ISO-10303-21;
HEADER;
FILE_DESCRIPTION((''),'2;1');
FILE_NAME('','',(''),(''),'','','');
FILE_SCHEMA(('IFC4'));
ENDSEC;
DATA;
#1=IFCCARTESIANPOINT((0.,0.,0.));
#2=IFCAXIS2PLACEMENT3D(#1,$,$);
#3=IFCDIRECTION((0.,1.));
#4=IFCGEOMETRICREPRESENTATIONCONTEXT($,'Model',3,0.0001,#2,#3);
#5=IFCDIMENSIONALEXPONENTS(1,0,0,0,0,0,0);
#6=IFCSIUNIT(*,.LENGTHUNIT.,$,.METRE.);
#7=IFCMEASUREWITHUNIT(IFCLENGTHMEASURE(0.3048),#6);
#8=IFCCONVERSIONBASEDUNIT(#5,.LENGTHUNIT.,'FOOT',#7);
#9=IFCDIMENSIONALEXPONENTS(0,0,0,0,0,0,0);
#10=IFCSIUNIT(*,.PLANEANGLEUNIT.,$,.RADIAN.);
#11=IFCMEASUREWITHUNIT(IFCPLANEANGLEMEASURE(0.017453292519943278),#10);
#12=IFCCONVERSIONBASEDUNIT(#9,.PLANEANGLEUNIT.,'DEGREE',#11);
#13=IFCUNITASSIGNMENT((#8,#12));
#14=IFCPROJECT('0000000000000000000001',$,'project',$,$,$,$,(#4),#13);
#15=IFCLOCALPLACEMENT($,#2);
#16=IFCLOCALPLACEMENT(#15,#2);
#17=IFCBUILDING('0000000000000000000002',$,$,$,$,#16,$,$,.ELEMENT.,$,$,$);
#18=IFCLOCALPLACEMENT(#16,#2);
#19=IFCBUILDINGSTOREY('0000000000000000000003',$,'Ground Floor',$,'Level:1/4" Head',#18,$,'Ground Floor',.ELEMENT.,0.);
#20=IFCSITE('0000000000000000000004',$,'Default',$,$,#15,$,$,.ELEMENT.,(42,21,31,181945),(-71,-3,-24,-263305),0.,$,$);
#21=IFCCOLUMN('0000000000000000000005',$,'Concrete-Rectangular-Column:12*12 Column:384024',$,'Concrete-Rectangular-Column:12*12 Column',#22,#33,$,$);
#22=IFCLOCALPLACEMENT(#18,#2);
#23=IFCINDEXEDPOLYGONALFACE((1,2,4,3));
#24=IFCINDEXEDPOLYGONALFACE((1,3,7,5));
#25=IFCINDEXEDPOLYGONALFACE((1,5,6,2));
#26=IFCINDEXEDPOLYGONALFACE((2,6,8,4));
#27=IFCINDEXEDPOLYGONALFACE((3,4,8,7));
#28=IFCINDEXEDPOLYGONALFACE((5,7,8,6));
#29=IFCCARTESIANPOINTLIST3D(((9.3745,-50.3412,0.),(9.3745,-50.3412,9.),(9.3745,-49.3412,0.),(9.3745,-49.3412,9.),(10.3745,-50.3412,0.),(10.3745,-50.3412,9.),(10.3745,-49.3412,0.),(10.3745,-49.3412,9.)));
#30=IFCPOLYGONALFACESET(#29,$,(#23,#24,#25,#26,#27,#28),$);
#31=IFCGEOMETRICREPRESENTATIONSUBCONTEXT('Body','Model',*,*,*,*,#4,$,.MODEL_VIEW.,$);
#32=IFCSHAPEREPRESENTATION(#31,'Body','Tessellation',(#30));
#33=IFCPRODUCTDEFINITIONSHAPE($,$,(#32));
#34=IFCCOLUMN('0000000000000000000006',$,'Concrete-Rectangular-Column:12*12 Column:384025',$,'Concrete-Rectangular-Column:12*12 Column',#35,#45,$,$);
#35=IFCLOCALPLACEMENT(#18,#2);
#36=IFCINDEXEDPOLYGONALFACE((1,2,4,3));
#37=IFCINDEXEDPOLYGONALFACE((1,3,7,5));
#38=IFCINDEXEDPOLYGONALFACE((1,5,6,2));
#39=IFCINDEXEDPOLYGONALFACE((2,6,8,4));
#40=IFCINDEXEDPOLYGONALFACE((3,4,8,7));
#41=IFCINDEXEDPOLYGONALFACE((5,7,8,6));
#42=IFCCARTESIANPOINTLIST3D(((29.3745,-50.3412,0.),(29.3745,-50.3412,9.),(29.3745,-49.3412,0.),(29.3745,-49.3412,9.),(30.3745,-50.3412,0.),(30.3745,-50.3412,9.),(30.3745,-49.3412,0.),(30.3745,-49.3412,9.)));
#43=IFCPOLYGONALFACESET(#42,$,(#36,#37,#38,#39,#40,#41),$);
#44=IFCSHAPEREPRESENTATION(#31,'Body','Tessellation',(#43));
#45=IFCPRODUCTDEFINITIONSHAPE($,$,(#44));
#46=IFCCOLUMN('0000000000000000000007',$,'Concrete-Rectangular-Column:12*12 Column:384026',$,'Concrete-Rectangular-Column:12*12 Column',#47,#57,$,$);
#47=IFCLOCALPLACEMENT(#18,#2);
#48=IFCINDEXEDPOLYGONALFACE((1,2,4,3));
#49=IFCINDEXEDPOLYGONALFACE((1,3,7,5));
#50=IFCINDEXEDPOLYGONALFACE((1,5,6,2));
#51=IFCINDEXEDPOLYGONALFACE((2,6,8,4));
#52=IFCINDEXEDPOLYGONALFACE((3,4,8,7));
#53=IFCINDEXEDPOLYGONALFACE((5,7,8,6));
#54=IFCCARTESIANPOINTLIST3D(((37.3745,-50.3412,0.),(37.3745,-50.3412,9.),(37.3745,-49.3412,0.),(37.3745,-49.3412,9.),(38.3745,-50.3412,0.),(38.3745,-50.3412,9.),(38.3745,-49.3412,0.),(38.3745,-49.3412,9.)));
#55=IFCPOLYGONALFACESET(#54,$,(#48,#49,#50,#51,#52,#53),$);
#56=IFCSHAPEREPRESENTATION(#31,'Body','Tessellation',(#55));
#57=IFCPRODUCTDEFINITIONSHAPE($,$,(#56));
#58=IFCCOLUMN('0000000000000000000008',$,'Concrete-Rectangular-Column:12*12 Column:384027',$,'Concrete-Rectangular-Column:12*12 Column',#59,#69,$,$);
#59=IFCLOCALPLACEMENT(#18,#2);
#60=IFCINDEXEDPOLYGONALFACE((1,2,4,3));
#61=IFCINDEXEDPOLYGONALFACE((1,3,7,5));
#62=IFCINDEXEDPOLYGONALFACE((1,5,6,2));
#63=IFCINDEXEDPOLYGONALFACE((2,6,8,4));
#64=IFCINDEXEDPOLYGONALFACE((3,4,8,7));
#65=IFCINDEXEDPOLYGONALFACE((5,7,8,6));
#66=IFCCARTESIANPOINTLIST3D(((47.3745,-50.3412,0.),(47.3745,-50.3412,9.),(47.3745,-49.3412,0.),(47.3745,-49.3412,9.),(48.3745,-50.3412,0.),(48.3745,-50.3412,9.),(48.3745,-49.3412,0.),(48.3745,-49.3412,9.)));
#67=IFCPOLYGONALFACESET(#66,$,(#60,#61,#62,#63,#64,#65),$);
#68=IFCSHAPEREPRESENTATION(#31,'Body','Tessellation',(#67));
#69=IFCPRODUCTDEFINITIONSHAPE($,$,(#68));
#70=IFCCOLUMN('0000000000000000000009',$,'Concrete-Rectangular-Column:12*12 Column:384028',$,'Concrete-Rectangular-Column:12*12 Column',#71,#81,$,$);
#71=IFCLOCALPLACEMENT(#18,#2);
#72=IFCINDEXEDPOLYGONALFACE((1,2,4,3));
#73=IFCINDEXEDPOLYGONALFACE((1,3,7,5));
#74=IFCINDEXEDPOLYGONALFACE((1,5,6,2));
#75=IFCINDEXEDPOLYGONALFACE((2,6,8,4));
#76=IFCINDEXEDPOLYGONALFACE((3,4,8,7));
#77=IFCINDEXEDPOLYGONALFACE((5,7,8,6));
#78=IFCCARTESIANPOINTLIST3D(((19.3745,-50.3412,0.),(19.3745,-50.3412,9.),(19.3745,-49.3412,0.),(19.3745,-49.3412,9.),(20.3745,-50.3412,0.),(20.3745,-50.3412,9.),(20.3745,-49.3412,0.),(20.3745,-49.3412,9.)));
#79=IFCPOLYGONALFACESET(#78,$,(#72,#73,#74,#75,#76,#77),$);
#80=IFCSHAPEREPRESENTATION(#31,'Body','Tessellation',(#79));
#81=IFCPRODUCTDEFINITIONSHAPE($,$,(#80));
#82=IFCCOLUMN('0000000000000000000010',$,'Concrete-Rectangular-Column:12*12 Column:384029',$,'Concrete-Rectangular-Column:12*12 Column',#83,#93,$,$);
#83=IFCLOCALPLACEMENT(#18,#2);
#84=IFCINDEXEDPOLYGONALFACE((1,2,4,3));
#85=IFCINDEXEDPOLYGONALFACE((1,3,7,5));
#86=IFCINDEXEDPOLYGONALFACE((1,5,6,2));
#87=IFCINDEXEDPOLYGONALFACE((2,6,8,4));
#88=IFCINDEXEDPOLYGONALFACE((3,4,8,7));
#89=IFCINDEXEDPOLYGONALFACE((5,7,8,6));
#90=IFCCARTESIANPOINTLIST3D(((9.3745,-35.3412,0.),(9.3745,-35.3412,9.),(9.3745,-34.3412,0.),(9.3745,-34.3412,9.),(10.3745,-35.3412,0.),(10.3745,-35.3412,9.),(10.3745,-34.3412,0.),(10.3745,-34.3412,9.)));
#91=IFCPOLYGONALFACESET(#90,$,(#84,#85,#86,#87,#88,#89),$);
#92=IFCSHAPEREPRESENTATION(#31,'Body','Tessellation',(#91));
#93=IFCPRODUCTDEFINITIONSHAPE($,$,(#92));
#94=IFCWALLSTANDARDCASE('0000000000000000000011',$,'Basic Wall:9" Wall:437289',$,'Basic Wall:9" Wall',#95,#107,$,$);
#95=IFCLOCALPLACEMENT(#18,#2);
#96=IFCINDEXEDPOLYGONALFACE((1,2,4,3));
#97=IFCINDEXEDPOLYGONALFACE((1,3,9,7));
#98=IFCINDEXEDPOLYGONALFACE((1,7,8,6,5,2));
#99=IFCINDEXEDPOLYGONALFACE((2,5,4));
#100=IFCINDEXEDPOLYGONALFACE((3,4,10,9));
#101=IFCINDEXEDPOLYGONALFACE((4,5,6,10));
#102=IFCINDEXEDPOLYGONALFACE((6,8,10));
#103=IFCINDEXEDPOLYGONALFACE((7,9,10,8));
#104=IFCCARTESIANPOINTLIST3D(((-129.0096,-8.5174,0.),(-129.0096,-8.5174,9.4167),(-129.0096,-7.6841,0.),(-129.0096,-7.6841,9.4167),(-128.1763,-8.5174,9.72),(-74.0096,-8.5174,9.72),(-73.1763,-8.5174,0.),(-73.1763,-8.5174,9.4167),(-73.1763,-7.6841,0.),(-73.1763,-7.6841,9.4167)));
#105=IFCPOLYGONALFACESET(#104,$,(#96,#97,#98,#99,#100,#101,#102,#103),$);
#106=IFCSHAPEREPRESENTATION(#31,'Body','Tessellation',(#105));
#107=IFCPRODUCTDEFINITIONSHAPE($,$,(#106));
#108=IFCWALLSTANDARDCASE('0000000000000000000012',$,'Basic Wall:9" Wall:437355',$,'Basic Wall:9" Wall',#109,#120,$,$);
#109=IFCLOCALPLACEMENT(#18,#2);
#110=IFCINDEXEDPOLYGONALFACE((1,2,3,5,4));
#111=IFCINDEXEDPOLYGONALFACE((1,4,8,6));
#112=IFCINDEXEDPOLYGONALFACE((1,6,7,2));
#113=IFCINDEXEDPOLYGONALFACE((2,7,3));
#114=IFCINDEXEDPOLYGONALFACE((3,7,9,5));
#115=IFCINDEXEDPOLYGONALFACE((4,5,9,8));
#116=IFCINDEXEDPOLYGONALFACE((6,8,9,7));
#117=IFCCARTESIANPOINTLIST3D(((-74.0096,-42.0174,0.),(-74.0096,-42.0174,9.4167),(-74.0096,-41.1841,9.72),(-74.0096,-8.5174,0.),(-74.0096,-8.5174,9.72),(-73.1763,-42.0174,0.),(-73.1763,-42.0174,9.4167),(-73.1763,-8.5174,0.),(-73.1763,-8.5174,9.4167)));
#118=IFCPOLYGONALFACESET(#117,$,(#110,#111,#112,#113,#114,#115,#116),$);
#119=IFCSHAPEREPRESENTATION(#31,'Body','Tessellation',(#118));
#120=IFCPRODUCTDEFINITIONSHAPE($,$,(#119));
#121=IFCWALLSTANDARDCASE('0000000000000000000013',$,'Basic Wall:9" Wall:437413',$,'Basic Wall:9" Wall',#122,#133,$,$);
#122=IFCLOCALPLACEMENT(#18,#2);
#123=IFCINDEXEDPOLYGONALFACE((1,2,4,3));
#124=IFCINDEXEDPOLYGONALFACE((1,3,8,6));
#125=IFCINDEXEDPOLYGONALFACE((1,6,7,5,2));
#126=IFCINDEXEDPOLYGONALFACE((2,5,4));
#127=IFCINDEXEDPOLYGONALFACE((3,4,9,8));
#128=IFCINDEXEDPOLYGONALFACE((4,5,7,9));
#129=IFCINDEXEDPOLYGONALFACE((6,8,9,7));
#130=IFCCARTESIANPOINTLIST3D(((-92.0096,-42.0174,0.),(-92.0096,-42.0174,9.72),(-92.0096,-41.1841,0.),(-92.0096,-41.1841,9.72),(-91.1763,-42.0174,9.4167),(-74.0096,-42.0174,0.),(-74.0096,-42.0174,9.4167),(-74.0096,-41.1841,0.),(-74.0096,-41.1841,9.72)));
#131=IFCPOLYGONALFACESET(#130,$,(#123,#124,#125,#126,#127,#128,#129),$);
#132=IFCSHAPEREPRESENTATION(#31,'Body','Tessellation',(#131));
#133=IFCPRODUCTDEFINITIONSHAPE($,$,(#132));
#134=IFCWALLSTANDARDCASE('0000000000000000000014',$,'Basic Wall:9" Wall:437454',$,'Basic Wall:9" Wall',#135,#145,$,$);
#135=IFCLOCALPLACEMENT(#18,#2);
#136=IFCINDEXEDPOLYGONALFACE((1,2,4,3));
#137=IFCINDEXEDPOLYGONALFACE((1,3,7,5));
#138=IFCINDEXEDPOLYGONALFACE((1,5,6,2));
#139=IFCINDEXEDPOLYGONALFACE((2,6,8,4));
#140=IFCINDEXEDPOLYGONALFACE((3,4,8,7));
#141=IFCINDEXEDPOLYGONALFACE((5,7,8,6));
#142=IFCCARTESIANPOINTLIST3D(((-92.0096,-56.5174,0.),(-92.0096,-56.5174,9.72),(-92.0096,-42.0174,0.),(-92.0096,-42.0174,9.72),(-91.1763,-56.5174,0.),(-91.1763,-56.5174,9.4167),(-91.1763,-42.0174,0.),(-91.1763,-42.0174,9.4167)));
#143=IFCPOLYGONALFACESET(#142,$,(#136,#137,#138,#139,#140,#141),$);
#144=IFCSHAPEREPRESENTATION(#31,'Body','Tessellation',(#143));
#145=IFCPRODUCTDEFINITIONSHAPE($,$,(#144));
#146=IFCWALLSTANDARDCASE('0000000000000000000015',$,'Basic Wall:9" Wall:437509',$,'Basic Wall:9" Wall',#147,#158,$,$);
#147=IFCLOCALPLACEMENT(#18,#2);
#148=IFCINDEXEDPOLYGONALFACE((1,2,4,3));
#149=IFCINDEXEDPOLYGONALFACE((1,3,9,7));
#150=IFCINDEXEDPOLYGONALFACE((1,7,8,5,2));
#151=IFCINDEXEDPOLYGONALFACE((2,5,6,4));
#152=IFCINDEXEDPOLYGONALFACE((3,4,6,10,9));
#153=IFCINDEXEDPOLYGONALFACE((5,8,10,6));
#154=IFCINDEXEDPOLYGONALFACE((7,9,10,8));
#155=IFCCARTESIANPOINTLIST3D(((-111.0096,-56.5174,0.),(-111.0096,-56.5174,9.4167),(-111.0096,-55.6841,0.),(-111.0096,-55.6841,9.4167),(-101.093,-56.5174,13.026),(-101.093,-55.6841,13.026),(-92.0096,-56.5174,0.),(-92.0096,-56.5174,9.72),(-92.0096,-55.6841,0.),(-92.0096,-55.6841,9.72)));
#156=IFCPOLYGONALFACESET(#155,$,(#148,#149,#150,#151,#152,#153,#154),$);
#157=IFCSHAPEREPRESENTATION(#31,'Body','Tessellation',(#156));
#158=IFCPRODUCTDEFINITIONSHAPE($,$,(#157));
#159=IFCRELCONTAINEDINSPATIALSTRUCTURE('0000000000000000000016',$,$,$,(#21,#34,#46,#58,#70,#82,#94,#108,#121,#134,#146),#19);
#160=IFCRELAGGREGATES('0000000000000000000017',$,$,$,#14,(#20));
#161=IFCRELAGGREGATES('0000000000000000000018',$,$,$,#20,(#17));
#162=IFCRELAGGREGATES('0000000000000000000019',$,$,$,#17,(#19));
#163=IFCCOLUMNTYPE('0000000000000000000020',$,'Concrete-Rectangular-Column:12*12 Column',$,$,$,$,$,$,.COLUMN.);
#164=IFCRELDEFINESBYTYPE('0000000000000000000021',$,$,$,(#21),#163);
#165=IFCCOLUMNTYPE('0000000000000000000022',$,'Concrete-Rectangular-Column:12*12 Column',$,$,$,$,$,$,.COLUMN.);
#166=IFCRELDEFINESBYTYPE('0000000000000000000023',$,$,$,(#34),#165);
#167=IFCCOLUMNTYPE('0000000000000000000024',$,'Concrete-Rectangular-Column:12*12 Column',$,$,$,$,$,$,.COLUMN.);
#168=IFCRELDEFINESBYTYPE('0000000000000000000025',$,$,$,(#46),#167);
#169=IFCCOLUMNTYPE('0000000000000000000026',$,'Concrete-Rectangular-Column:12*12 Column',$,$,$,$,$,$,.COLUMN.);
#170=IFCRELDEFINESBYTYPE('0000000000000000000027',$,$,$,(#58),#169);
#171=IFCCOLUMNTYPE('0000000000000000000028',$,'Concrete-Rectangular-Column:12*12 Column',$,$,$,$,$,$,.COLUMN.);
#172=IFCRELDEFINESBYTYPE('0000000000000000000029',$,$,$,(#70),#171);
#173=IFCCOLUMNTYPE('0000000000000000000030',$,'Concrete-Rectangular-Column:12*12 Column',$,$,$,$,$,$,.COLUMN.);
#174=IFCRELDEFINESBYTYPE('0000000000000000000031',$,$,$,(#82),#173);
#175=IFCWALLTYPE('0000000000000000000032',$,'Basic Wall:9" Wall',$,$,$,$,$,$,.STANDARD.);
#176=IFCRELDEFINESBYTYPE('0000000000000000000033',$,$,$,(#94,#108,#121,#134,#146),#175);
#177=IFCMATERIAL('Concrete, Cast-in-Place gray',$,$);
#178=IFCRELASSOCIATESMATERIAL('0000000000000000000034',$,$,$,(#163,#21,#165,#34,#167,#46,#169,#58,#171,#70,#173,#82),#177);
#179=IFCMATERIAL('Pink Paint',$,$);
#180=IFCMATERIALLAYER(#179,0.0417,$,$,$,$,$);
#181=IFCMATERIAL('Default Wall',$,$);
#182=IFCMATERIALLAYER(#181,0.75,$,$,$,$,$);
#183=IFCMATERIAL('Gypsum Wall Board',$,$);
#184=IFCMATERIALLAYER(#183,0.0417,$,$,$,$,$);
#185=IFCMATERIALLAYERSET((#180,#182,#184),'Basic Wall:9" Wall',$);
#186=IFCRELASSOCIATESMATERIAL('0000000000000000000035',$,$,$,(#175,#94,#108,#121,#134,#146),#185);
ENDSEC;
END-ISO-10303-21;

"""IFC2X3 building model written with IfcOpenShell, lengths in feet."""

from ifc_helpers import new_model, entity, si_unit, converted_unit, direction, frame, frame_2d, origin, origin_2d_with_axis, place, context, subcontext, project, spatial, polyline, rectangle, extrude, clip, bounded_halfspace, source, transform, mapped, material, layer, layer_set, layer_usage, type_object, type_shapes, element, save


model = new_model("IFC2X3")

# Units and contexts
model_context = context("Model", 3, precision=0.0001, world=origin(), true_north=direction((0.0, 1.0)))
body_context = subcontext(model_context, "Body", "Model", "MODEL_VIEW")
ifc_project = project(units=[converted_unit("LENGTHUNIT", "FOOT", entity("IfcLengthMeasure", 0.3048), si_unit("LENGTHUNIT", "METRE"), dimensions=[1, 0, 0, 0, 0, 0, 0]), converted_unit("PLANEANGLEUNIT", "DEGREE", entity("IfcPlaneAngleMeasure", 0.017453292519943278), si_unit("PLANEANGLEUNIT", "RADIAN"), dimensions=[0, 0, 0, 0, 0, 0, 0])], contexts=[model_context])

# Site, building, storey
site_placement = place(None, origin())
site = spatial("IfcSite", under=ifc_project, at=site_placement, Name="Default", CompositionType="ELEMENT", RefLatitude=(42, 21, 31, 181945), RefLongitude=(-71, -3, -24, -263305), RefElevation=0.0)
building_placement = place(site_placement, origin())
building = spatial("IfcBuilding", under=site, at=building_placement, CompositionType="ELEMENT")
storey_placement = place(building_placement, origin())
storey = spatial("IfcBuildingStorey", under=building, at=storey_placement, Name="Ground Floor", ObjectType="Level:1/4\" Head", LongName="Ground Floor", CompositionType="ELEMENT", Elevation=0.0)

# Columns
ifc_material_1 = material(Name="Concrete, Cast-in-Place gray")
column_type_1 = type_object("IfcColumnType", Name="Concrete-Rectangular-Column:12*12 Column", PredefinedType="COLUMN", material=ifc_material_1)
shared_shape_1 = source(origin(), body_context, "Body", "SweptSolid", [
    extrude(rectangle(XDim=1.0, YDim=1.0, at=origin_2d_with_axis()), frame((9.8745, -49.8412, 0.0), z_axis=(0.0, 0.0, 1.0), x_axis=(-1.0, 0.0, 0.0)), (0.0, 0.0, 1.0), 9.0),
])
type_shapes(column_type_1, [shared_shape_1])
column_1_placement = place(storey_placement, origin())
element("IfcColumn", 1, at=column_1_placement, inside=storey, type_object=column_type_1, material=ifc_material_1, Name="Concrete-Rectangular-Column:12*12 Column:384024", ObjectType="Concrete-Rectangular-Column:12*12 Column", context=body_context, shape_type="MappedRepresentation", body=[
    mapped(shared_shape_1, transform((0.0, 0.0, 0.0), scale=1.0)),
])
column_type_2 = type_object("IfcColumnType", Name="Concrete-Rectangular-Column:12*12 Column", PredefinedType="COLUMN", material=ifc_material_1)
shared_shape_2 = source(origin(), body_context, "Body", "SweptSolid", [
    extrude(rectangle(XDim=1.0, YDim=1.0, at=frame_2d((0.0, 0.0), x_axis=(1.0, 0.0))), frame((29.8745, -49.8412, 0.0), z_axis=(0.0, 0.0, 1.0), x_axis=(-1.0, 0.0, 0.0)), (0.0, 0.0, 1.0), 9.0),
])
type_shapes(column_type_2, [shared_shape_2])
column_2_placement = place(storey_placement, origin())
element("IfcColumn", 2, at=column_2_placement, inside=storey, type_object=column_type_2, material=ifc_material_1, Name="Concrete-Rectangular-Column:12*12 Column:384025", ObjectType="Concrete-Rectangular-Column:12*12 Column", context=body_context, shape_type="MappedRepresentation", body=[
    mapped(shared_shape_2, transform((0.0, 0.0, 0.0), scale=1.0)),
])
column_type_3 = type_object("IfcColumnType", Name="Concrete-Rectangular-Column:12*12 Column", PredefinedType="COLUMN", material=ifc_material_1)
shared_shape_3 = source(origin(), body_context, "Body", "SweptSolid", [
    extrude(rectangle(XDim=1.0, YDim=1.0, at=origin_2d_with_axis()), frame((37.8745, -49.8412, 0.0), z_axis=(0.0, 0.0, 1.0), x_axis=(-1.0, 0.0, 0.0)), (0.0, 0.0, 1.0), 9.0),
])
type_shapes(column_type_3, [shared_shape_3])
column_3_placement = place(storey_placement, origin())
element("IfcColumn", 3, at=column_3_placement, inside=storey, type_object=column_type_3, material=ifc_material_1, Name="Concrete-Rectangular-Column:12*12 Column:384026", ObjectType="Concrete-Rectangular-Column:12*12 Column", context=body_context, shape_type="MappedRepresentation", body=[
    mapped(shared_shape_3, transform((0.0, 0.0, 0.0), scale=1.0)),
])
column_type_4 = type_object("IfcColumnType", Name="Concrete-Rectangular-Column:12*12 Column", PredefinedType="COLUMN", material=ifc_material_1)
shared_shape_4 = source(origin(), body_context, "Body", "SweptSolid", [
    extrude(rectangle(XDim=1.0, YDim=1.0, at=origin_2d_with_axis()), frame((47.8745, -49.8412, 0.0), z_axis=(0.0, 0.0, 1.0), x_axis=(-1.0, 0.0, 0.0)), (0.0, 0.0, 1.0), 9.0),
])
type_shapes(column_type_4, [shared_shape_4])
column_4_placement = place(storey_placement, origin())
element("IfcColumn", 4, at=column_4_placement, inside=storey, type_object=column_type_4, material=ifc_material_1, Name="Concrete-Rectangular-Column:12*12 Column:384027", ObjectType="Concrete-Rectangular-Column:12*12 Column", context=body_context, shape_type="MappedRepresentation", body=[
    mapped(shared_shape_4, transform((0.0, 0.0, 0.0), scale=1.0)),
])
column_type_5 = type_object("IfcColumnType", Name="Concrete-Rectangular-Column:12*12 Column", PredefinedType="COLUMN", material=ifc_material_1)
shared_shape_5 = source(origin(), body_context, "Body", "SweptSolid", [
    extrude(rectangle(XDim=1.0, YDim=1.0, at=frame_2d((0.0, 0.0), x_axis=(1.0, 0.0))), frame((19.8745, -49.8412, 0.0), z_axis=(0.0, 0.0, 1.0), x_axis=(-1.0, 0.0, 0.0)), (0.0, 0.0, 1.0), 9.0),
])
type_shapes(column_type_5, [shared_shape_5])
column_5_placement = place(storey_placement, origin())
element("IfcColumn", 5, at=column_5_placement, inside=storey, type_object=column_type_5, material=ifc_material_1, Name="Concrete-Rectangular-Column:12*12 Column:384028", ObjectType="Concrete-Rectangular-Column:12*12 Column", context=body_context, shape_type="MappedRepresentation", body=[
    mapped(shared_shape_5, transform((0.0, 0.0, 0.0), scale=1.0)),
])
column_type_6 = type_object("IfcColumnType", Name="Concrete-Rectangular-Column:12*12 Column", PredefinedType="COLUMN", material=ifc_material_1)
shared_shape_6 = source(origin(), body_context, "Body", "SweptSolid", [
    extrude(rectangle(XDim=1.0, YDim=1.0, at=origin_2d_with_axis()), frame((9.8745, -34.8412, 0.0), z_axis=(0.0, 0.0, 1.0), x_axis=(-1.0, 0.0, 0.0)), (0.0, 0.0, 1.0), 9.0),
])
type_shapes(column_type_6, [shared_shape_6])
column_6_placement = place(storey_placement, origin())
element("IfcColumn", 6, at=column_6_placement, inside=storey, type_object=column_type_6, material=ifc_material_1, Name="Concrete-Rectangular-Column:12*12 Column:384029", ObjectType="Concrete-Rectangular-Column:12*12 Column", context=body_context, shape_type="MappedRepresentation", body=[
    mapped(shared_shape_6, transform((0.0, 0.0, 0.0), scale=1.0)),
])

# Walls
ifc_material_2 = material(Name="Pink Paint")
ifc_layer_1 = layer(ifc_material_2, 0.0417)
ifc_material_3 = material(Name="Default Wall")
ifc_layer_2 = layer(ifc_material_3, 0.75)
ifc_material_4 = material(Name="Gypsum Wall Board")
ifc_layer_3 = layer(ifc_material_4, 0.0417)
ifc_layer_set_1 = layer_set([ifc_layer_1, ifc_layer_2, ifc_layer_3], Name="Basic Wall:9\" Wall")
ifc_layer_usage_1 = layer_usage(ifc_layer_set_1, "AXIS2", "NEGATIVE", 0.4167)
wall_type_1 = type_object("IfcWallType", Name="Basic Wall:9\" Wall", PredefinedType="STANDARD", material=ifc_layer_set_1)
wall_1_placement = place(storey_placement, frame((-129.0096, -8.1008, 0.0)))
element("IfcWallStandardCase", 7, at=wall_1_placement, inside=storey, type_object=wall_type_1, material=ifc_layer_usage_1, Name="Basic Wall:9\" Wall:437289", ObjectType="Basic Wall:9\" Wall", context=body_context, shape_type="Clipping", body=[
    clip(clip(clip(extrude(rectangle(XDim=55.8333, YDim=0.8333, at=frame_2d((27.9167, 0.0), x_axis=(-1.0, 0.0))), origin(), (0.0, 0.0, 1.0), 9.72), bounded_halfspace(frame((0.0, -0.4167, 9.4167), z_axis=(-0.34202, 0.0, 0.939693), x_axis=(0.0, -1.0, 0.0)), False, frame((0.0, -0.4167, 9.4167)), polyline([(0.0, 0.0), (0.8333, 0.0), (0.0, 0.8333), (0.0, 0.0)]))), bounded_halfspace(frame((55.0, -0.4167, 9.72), z_axis=(0.34202, 0.0, 0.939693), x_axis=(0.0, 1.0, 0.0)), False, frame((55.0, -0.4167, 9.72)), polyline([(0.0, 0.0), (0.8333, 0.0), (0.8333, 0.8333), (0.0, 0.0)]))), bounded_halfspace(frame((0.8333, -0.4167, 9.72), z_axis=(0.0, 0.34202, 0.939693), x_axis=(-1.0, 0.0, 0.0)), False, frame((0.8333, -0.4167, 9.72)), polyline([(0.0, 0.0), (54.1667, 0.0), (55.0, 0.8333), (-0.8333, 0.8333), (0.0, 0.0)]))),
])
wall_2_placement = place(storey_placement, frame((-73.593, -8.5174, 0.0), z_axis=(0.0, 0.0, 1.0), x_axis=(0.0, -1.0, 0.0)))
element("IfcWallStandardCase", 8, at=wall_2_placement, inside=storey, type_object=wall_type_1, material=ifc_layer_usage_1, Name="Basic Wall:9\" Wall:437355", ObjectType="Basic Wall:9\" Wall", context=body_context, shape_type="Clipping", body=[
    clip(clip(extrude(rectangle(XDim=33.5, YDim=0.8333, at=frame_2d((16.75, 0.0), x_axis=(-1.0, 0.0))), origin(), (0.0, 0.0, 1.0), 9.72), bounded_halfspace(frame((0.0, -0.4167, 9.72), z_axis=(0.0, 0.34202, 0.939693), x_axis=(-1.0, 0.0, 0.0)), False, frame((0.0, -0.4167, 9.72)), polyline([(0.0, 0.0), (32.6667, 0.0), (33.5, 0.8333), (0.0, 0.8333), (0.0, 0.0)]))), bounded_halfspace(frame((32.6667, -0.4167, 9.72), z_axis=(0.34202, 0.0, 0.939693), x_axis=(0.0, 1.0, 0.0)), False, frame((32.6667, -0.4167, 9.72)), polyline([(0.0, 0.0), (0.8333, 0.0), (0.8333, 0.8333), (0.0, 0.0)]))),
])
wall_3_placement = place(storey_placement, frame((-74.0096, -41.6008, 0.0), z_axis=(0.0, 0.0, 1.0), x_axis=(-1.0, 0.0, 0.0)))
element("IfcWallStandardCase", 9, at=wall_3_placement, inside=storey, type_object=wall_type_1, material=ifc_layer_usage_1, Name="Basic Wall:9\" Wall:437413", ObjectType="Basic Wall:9\" Wall", context=body_context, shape_type="Clipping", body=[
    clip(clip(extrude(rectangle(XDim=18.0, YDim=0.8333, at=frame_2d((9.0, 0.0), x_axis=(-1.0, 0.0))), origin(), (0.0, 0.0, 1.0), 9.72), bounded_halfspace(frame((18.0, -0.4167, 9.72), z_axis=(-0.34202, 0.0, 0.939693), x_axis=(0.0, -1.0, 0.0)), False, frame((18.0, -0.4167, 9.72)), polyline([(0.0, 0.0), (0.0, 0.8333), (-0.8333, 0.8333), (0.0, 0.0)]))), bounded_halfspace(frame((0.0, -0.4167, 9.72), z_axis=(0.0, 0.34202, 0.939693), x_axis=(-1.0, 0.0, 0.0)), False, frame((0.0, -0.4167, 9.72)), polyline([(0.0, 0.0), (18.0, 0.0), (17.1667, 0.8333), (0.0, 0.8333), (0.0, 0.0)]))),
])
wall_4_placement = place(storey_placement, frame((-91.593, -42.0174, 0.0), z_axis=(0.0, 0.0, 1.0), x_axis=(0.0, -1.0, 0.0)))
element("IfcWallStandardCase", 10, at=wall_4_placement, inside=storey, type_object=wall_type_1, material=ifc_layer_usage_1, Name="Basic Wall:9\" Wall:437454", ObjectType="Basic Wall:9\" Wall", context=body_context, shape_type="Clipping", body=[
    clip(extrude(rectangle(XDim=14.5, YDim=0.8333, at=frame_2d((7.25, 0.0), x_axis=(-1.0, 0.0))), origin(), (0.0, 0.0, 1.0), 9.72), bounded_halfspace(frame((0.0, -0.4167, 9.72), z_axis=(0.0, 0.34202, 0.939693), x_axis=(-1.0, 0.0, 0.0)), False, frame((0.0, -0.4167, 9.72)), polyline([(0.0, 0.0), (13.6667, 0.0), (14.5, 0.0), (14.5, 0.8333), (0.0, 0.8333), (0.0, 0.0)]))),
])
wall_5_placement = place(storey_placement, frame((-92.0096, -56.1008, 0.0), z_axis=(0.0, 0.0, 1.0), x_axis=(-1.0, 0.0, 0.0)))
element("IfcWallStandardCase", 11, at=wall_5_placement, inside=storey, type_object=wall_type_1, material=ifc_layer_usage_1, Name="Basic Wall:9\" Wall:437509", ObjectType="Basic Wall:9\" Wall", context=body_context, shape_type="Clipping", body=[
    clip(clip(extrude(rectangle(XDim=19.0, YDim=0.8333, at=frame_2d((9.5, 0.0), x_axis=(-1.0, 0.0))), origin(), (0.0, 0.0, 1.0), 13.026), bounded_halfspace(frame((9.0833, -0.4167, 13.026), z_axis=(0.34202, 0.0, 0.939693), x_axis=(0.0, 1.0, 0.0)), False, frame((9.0833, -0.4167, 13.026)), polyline([(0.0, 0.0), (9.0833, 0.0), (9.9167, 0.0), (9.9167, 0.8333), (0.0, 0.8333), (0.0, 0.0)]))), bounded_halfspace(frame((0.0, -0.4167, 9.72), z_axis=(-0.34202, 0.0, 0.939693), x_axis=(0.0, -1.0, 0.0)), False, frame((0.0, -0.4167, 9.72)), polyline([(0.0, 0.0), (9.0833, 0.0), (9.0833, 0.8333), (0.0, 0.8333), (0.0, 0.0)]))),
])

save(model, "model.ifc")
